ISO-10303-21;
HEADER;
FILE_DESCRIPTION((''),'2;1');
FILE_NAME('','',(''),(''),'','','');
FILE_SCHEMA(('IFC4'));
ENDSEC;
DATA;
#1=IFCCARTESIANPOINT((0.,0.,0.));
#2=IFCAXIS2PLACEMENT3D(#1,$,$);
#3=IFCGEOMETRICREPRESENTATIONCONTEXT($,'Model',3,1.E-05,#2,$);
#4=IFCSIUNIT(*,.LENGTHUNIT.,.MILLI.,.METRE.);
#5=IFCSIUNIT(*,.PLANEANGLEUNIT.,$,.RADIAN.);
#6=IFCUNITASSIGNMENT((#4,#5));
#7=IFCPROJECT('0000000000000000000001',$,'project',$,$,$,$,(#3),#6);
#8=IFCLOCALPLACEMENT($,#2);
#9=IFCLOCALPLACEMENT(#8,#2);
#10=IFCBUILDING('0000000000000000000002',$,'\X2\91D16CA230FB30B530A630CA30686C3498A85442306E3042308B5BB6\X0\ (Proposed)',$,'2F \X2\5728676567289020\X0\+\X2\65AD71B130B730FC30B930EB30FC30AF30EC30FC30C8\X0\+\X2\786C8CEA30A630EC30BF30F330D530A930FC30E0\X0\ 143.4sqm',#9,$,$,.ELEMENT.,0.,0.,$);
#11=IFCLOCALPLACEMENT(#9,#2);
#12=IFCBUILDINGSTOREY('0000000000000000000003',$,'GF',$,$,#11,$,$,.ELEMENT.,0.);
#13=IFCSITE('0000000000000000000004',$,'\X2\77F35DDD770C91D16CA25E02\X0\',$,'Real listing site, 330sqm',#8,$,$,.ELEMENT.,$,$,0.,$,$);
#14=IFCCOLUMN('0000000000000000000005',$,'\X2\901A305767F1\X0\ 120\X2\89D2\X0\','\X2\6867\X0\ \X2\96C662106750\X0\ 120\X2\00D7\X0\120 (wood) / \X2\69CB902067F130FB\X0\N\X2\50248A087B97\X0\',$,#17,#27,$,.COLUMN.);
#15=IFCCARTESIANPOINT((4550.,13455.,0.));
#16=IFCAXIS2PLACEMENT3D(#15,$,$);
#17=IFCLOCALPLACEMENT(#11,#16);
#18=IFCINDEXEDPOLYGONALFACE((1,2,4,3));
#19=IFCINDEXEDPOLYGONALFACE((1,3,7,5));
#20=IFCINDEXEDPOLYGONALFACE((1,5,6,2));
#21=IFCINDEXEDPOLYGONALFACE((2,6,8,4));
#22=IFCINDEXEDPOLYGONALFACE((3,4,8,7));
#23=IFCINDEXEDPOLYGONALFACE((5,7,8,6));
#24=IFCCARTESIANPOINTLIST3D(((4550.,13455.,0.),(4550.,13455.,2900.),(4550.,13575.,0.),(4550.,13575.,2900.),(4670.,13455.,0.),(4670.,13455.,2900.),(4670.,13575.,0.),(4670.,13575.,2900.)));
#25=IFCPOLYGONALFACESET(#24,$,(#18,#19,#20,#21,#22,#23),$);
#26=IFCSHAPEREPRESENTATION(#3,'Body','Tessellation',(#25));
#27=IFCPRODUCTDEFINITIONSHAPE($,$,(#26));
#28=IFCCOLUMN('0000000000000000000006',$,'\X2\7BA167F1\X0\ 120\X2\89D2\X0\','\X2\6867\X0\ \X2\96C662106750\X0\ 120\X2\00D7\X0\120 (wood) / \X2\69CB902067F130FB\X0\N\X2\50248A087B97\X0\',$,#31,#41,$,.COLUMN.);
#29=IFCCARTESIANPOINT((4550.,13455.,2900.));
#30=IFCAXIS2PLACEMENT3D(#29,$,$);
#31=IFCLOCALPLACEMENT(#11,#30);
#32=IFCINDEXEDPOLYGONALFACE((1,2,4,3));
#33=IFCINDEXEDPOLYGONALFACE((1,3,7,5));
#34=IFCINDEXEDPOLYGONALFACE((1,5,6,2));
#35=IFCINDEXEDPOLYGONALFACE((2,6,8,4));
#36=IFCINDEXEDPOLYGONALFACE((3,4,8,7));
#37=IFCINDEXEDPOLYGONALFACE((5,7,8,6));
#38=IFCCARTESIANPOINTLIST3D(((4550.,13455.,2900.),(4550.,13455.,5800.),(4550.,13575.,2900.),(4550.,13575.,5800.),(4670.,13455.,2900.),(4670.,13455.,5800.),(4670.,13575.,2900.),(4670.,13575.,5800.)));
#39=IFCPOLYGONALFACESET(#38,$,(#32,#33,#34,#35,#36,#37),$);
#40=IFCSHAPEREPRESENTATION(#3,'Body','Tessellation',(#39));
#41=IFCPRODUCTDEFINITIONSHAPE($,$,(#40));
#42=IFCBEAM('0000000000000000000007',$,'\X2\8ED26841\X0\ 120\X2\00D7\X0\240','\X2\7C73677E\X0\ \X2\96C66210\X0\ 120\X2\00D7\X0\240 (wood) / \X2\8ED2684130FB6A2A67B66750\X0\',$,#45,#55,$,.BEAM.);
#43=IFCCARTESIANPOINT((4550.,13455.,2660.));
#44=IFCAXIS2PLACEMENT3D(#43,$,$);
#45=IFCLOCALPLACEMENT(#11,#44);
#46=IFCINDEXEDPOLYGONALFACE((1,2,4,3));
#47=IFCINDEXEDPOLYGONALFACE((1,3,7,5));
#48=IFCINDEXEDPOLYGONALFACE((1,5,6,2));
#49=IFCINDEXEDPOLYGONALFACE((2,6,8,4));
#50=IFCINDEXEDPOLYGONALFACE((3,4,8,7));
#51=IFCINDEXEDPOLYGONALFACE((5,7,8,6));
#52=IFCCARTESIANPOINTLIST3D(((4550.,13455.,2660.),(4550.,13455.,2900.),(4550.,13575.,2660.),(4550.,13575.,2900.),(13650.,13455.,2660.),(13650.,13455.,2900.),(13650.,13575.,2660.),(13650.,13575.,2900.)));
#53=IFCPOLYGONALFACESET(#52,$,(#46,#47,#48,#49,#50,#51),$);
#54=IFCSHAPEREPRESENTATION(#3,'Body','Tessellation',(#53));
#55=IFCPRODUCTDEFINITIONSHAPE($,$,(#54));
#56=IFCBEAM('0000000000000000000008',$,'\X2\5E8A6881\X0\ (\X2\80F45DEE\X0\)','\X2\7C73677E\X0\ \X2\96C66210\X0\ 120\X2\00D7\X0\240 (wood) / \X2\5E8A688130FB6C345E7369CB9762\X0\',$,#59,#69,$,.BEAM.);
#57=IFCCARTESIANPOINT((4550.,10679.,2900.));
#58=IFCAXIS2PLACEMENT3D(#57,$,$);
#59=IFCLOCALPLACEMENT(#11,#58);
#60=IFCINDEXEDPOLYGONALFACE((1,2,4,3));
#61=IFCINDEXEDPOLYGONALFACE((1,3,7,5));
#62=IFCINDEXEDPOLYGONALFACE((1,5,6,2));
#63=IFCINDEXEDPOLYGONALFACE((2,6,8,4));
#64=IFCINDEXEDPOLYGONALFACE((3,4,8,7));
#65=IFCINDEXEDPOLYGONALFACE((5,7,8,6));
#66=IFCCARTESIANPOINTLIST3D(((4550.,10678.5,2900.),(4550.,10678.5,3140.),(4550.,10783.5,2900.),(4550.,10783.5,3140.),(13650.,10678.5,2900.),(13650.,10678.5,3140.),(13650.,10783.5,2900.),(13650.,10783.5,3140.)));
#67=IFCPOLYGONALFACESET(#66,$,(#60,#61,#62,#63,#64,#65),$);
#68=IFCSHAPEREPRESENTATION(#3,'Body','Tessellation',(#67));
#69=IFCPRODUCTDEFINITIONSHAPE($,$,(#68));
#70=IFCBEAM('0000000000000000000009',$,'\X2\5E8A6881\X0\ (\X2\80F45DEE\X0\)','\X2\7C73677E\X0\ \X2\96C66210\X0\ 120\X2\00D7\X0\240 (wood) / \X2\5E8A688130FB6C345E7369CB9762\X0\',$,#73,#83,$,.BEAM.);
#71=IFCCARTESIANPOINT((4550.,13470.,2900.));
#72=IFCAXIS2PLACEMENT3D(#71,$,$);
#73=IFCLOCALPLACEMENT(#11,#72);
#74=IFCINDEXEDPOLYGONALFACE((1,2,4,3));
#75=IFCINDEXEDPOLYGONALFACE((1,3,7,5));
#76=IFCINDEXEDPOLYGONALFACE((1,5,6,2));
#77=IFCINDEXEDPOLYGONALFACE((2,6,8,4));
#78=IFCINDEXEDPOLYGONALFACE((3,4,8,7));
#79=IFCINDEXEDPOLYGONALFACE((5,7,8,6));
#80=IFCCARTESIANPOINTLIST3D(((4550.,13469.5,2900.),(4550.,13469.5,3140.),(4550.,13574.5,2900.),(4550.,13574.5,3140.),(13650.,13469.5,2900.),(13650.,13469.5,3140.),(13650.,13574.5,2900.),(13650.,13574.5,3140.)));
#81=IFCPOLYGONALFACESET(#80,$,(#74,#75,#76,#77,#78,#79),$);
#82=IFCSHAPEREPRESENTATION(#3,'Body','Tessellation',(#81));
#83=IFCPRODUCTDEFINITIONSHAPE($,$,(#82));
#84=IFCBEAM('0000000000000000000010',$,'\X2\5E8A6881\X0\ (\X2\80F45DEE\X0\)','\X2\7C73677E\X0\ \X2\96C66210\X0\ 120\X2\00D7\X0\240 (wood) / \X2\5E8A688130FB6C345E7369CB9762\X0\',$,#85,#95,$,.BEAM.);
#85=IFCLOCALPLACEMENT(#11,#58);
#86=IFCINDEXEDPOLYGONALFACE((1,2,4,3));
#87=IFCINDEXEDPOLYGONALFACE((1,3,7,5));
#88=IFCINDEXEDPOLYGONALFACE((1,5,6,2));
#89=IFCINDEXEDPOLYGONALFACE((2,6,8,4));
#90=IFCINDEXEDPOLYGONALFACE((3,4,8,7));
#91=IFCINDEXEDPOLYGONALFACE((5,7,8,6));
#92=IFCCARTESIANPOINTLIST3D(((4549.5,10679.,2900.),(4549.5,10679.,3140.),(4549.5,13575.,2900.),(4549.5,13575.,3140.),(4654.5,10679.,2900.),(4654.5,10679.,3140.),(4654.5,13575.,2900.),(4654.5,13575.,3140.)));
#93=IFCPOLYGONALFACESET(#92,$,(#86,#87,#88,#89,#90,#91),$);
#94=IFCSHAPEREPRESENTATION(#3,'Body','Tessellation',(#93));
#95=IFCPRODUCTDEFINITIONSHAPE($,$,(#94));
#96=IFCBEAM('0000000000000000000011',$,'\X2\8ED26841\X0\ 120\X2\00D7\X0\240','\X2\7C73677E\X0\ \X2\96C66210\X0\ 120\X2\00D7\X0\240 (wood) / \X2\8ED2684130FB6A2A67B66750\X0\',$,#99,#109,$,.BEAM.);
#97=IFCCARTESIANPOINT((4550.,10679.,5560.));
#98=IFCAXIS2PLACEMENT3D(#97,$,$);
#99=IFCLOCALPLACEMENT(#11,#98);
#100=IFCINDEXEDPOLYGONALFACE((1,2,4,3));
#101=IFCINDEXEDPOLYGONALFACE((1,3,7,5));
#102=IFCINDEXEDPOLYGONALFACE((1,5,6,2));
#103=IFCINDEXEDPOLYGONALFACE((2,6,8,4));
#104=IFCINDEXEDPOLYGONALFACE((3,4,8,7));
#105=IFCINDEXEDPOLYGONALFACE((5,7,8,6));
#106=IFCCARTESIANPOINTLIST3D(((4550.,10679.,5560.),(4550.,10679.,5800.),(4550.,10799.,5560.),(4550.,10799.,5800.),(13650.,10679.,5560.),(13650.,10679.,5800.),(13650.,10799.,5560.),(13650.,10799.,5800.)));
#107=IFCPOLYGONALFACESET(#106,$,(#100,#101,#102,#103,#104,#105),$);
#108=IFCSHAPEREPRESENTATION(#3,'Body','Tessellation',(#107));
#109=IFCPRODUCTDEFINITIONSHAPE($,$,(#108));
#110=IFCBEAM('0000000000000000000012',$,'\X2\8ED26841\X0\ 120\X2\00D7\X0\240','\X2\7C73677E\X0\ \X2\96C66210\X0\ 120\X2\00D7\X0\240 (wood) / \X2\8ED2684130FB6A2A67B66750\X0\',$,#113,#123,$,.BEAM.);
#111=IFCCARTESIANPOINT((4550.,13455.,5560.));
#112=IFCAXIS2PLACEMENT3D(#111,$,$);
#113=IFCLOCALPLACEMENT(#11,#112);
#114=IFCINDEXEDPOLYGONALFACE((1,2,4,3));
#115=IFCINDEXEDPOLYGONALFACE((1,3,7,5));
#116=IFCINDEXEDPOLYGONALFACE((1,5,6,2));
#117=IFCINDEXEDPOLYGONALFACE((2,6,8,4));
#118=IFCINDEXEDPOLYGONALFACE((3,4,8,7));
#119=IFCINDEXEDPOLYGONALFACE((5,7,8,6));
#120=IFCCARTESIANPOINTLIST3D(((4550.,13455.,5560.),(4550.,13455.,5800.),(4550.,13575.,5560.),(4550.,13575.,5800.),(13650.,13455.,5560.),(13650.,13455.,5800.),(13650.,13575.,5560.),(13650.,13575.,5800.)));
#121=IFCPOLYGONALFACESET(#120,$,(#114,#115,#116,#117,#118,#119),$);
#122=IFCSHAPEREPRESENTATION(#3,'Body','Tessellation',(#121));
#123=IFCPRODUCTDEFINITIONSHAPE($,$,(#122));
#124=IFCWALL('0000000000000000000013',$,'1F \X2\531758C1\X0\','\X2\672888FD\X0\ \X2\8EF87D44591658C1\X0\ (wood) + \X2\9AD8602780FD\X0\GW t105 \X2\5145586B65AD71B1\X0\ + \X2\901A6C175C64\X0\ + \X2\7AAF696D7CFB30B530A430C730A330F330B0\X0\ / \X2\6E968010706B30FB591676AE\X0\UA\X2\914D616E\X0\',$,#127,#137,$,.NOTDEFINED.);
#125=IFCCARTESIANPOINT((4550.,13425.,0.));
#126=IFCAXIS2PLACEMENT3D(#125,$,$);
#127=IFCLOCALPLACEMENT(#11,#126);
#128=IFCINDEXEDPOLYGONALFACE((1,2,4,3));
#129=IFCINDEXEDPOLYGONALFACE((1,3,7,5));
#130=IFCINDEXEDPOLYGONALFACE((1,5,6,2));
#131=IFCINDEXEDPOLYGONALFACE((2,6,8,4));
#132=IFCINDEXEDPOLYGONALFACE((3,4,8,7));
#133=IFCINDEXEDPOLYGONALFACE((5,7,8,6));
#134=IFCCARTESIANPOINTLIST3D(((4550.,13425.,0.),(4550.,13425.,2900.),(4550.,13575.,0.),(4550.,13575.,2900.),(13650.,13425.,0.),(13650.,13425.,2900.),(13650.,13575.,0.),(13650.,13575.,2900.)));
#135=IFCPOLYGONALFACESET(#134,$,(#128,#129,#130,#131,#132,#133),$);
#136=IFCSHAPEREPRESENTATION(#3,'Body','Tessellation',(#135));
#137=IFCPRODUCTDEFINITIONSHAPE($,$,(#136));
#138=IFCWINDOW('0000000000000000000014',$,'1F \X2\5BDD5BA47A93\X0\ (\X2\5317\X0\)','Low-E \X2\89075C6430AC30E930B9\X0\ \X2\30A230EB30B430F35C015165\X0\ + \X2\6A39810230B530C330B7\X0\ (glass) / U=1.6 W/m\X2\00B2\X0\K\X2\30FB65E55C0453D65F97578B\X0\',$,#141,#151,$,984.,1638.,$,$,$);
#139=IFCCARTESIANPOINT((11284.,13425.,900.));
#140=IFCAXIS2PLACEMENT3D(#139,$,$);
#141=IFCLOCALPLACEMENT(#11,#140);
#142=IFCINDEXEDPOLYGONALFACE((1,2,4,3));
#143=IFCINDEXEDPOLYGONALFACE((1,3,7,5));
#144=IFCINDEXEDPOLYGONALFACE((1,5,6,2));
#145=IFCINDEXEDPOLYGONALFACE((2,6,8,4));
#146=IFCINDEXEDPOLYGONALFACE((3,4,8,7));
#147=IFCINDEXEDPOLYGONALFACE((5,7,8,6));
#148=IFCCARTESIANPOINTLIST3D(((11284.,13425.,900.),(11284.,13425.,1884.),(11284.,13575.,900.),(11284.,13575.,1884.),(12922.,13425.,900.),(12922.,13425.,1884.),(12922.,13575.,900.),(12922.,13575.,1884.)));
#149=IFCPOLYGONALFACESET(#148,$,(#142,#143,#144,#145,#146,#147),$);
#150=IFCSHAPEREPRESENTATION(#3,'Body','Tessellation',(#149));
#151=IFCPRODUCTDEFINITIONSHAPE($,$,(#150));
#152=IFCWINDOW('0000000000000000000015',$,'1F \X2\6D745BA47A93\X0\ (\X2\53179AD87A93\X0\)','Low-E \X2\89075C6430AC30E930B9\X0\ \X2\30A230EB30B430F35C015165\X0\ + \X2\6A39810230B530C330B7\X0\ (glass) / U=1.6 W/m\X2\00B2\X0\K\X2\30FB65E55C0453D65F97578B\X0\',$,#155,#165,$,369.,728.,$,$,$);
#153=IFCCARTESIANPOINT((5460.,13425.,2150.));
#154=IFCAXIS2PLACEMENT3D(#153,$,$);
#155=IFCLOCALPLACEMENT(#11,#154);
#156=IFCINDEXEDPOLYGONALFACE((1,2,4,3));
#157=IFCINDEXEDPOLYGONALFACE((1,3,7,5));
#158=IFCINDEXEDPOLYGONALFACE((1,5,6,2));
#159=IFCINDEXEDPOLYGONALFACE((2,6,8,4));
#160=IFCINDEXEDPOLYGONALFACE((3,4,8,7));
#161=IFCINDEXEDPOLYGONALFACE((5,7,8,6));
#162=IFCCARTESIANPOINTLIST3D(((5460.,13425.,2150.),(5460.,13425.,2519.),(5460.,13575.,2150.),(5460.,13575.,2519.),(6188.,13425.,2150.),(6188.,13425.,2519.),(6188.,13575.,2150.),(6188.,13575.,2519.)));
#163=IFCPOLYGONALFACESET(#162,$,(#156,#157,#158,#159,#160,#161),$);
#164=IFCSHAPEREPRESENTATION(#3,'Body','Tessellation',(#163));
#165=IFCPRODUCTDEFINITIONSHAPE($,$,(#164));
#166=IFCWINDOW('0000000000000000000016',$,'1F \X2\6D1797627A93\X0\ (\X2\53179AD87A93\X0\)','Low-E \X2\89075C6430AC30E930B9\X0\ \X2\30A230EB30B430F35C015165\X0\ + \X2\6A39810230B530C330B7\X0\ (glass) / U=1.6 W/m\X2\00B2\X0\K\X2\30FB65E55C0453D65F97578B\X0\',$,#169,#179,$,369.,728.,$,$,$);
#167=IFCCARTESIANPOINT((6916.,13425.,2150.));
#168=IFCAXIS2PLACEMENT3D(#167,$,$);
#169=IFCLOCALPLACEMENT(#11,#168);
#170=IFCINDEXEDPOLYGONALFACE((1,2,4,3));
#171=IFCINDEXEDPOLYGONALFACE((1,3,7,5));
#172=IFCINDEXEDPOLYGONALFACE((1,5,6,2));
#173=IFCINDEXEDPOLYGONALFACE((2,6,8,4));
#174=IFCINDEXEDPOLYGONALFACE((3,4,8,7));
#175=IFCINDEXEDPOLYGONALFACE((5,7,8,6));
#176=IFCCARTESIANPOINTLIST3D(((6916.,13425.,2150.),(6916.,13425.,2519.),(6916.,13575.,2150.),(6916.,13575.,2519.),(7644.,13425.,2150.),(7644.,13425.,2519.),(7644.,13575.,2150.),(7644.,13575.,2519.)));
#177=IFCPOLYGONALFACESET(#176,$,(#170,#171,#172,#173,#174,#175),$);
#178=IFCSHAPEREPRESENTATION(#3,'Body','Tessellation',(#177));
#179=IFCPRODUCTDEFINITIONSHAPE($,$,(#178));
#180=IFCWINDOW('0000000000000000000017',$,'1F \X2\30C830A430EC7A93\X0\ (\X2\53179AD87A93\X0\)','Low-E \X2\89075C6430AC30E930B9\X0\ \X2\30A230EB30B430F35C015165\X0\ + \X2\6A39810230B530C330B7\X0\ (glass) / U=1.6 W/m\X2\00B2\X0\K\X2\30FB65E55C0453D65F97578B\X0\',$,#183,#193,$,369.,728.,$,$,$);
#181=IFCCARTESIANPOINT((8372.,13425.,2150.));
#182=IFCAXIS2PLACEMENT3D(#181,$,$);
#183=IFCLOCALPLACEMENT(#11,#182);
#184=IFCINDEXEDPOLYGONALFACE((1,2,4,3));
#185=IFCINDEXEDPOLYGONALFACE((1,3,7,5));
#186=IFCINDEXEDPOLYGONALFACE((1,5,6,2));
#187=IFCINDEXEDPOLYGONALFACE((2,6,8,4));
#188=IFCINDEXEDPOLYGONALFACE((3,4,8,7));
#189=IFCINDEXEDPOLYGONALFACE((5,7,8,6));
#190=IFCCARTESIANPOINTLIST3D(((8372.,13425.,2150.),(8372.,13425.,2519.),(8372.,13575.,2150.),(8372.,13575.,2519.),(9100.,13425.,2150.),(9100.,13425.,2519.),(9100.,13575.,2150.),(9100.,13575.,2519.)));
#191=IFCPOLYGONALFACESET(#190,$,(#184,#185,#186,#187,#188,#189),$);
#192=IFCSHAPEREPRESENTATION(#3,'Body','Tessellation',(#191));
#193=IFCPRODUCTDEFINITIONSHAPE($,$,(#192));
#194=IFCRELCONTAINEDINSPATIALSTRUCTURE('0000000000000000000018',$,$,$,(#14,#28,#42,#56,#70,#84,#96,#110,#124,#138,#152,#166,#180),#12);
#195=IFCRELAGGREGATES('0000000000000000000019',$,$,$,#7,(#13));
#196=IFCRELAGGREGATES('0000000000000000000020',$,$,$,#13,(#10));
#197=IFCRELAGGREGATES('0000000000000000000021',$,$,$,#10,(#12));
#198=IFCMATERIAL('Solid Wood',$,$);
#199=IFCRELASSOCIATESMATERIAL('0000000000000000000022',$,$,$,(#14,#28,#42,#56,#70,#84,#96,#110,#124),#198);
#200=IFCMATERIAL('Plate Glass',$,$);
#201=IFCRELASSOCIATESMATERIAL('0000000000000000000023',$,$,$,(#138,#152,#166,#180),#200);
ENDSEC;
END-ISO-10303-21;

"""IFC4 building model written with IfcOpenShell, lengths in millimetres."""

from ifc_helpers import new_model, si_unit, frame, frame_2d, origin, place, context, project, spatial, rectangle, extrude, material, element, fill, save


model = new_model("IFC4")

# Units and contexts
model_context = context("Model", 3, precision=1e-05, world=origin())
ifc_project = project(units=[si_unit("LENGTHUNIT", "METRE", prefix="MILLI"), si_unit("PLANEANGLEUNIT", "RADIAN")], contexts=[model_context])

# Site, building, storey
site_placement = place(None, origin())
site = spatial("IfcSite", under=ifc_project, at=site_placement, Name="石川県金沢市", ObjectType="Real listing site, 330sqm", CompositionType="ELEMENT", RefElevation=0.0)
building_placement = place(site_placement, origin())
building = spatial("IfcBuilding", under=site, at=building_placement, Name="金沢・サウナと水風呂のある家 (Proposed)", ObjectType="2F 在来木造+断熱シースルークレート+硬質ウレタンフォーム 143.4sqm", CompositionType="ELEMENT", ElevationOfRefHeight=0.0, ElevationOfTerrain=0.0)
storey_placement = place(building_placement, origin())
storey = spatial("IfcBuildingStorey", under=building, at=storey_placement, Name="GF", CompositionType="ELEMENT", Elevation=0.0)

# Columns
ifc_material_1 = material(Name="Solid Wood")
column_1_placement = place(storey_placement, frame((4550.0, 13455.0, 0.0)))
element("IfcColumn", 1, at=column_1_placement, inside=storey, material=ifc_material_1, Name="通し柱 120角", Description="桧 集成材 120×120 (wood) / 構造柱・N値計算", PredefinedType="COLUMN", context=model_context, shape_type="SweptSolid", body=[
    extrude(rectangle(XDim=120.0, YDim=120.0, at=frame_2d((60.0, 60.0))), frame((4550.0, 13455.0, 0.0)), (0.0, 0.0, 1.0), 2900.0),
])
column_2_placement = place(storey_placement, frame((4550.0, 13455.0, 2900.0)))
element("IfcColumn", 2, at=column_2_placement, inside=storey, material=ifc_material_1, Name="管柱 120角", Description="桧 集成材 120×120 (wood) / 構造柱・N値計算", PredefinedType="COLUMN", context=model_context, shape_type="SweptSolid", body=[
    extrude(rectangle(XDim=120.0, YDim=120.0, at=frame_2d((60.0, 60.0))), frame((4550.0, 13455.0, 2900.0)), (0.0, 0.0, 1.0), 2900.0),
])

# Beams
beam_1_placement = place(storey_placement, frame((4550.0, 13455.0, 2660.0)))
element("IfcBeam", 3, at=beam_1_placement, inside=storey, material=ifc_material_1, Name="軒桁 120×240", Description="米松 集成 120×240 (wood) / 軒桁・横架材", PredefinedType="BEAM", context=model_context, shape_type="SweptSolid", body=[
    extrude(rectangle(XDim=9100.0, YDim=120.0, at=frame_2d((4550.0, 60.0))), frame((4550.0, 13455.0, 2660.0)), (0.0, 0.0, 1.0), 240.0),
])
beam_2_placement = place(storey_placement, frame((4550.0, 10679.0, 2900.0)))
element("IfcBeam", 4, at=beam_2_placement, inside=storey, material=ifc_material_1, Name="床梁 (胴差)", Description="米松 集成 120×240 (wood) / 床梁・水平構面", PredefinedType="BEAM", context=model_context, shape_type="SweptSolid", body=[
    extrude(rectangle(XDim=9100.0, YDim=105.0, at=frame_2d((4550.0, 52.0))), frame((4550.0, 10679.0, 2900.0)), (0.0, 0.0, 1.0), 240.0),
])
beam_3_placement = place(storey_placement, frame((4550.0, 13470.0, 2900.0)))
element("IfcBeam", 5, at=beam_3_placement, inside=storey, material=ifc_material_1, Name="床梁 (胴差)", Description="米松 集成 120×240 (wood) / 床梁・水平構面", PredefinedType="BEAM", context=model_context, shape_type="SweptSolid", body=[
    extrude(rectangle(XDim=9100.0, YDim=105.0, at=frame_2d((4550.0, 52.0))), frame((4550.0, 13470.0, 2900.0)), (0.0, 0.0, 1.0), 240.0),
])
beam_4_placement = place(storey_placement, frame((4550.0, 10679.0, 2900.0)))
element("IfcBeam", 6, at=beam_4_placement, inside=storey, material=ifc_material_1, Name="床梁 (胴差)", Description="米松 集成 120×240 (wood) / 床梁・水平構面", PredefinedType="BEAM", context=model_context, shape_type="SweptSolid", body=[
    extrude(rectangle(XDim=105.0, YDim=2896.0, at=frame_2d((52.0, 1448.0))), frame((4550.0, 10679.0, 2900.0)), (0.0, 0.0, 1.0), 240.0),
])
beam_5_placement = place(storey_placement, frame((4550.0, 10679.0, 5560.0)))
element("IfcBeam", 7, at=beam_5_placement, inside=storey, material=ifc_material_1, Name="軒桁 120×240", Description="米松 集成 120×240 (wood) / 軒桁・横架材", PredefinedType="BEAM", context=model_context, shape_type="SweptSolid", body=[
    extrude(rectangle(XDim=9100.0, YDim=120.0, at=frame_2d((4550.0, 60.0))), frame((4550.0, 10679.0, 5560.0)), (0.0, 0.0, 1.0), 240.0),
])
beam_6_placement = place(storey_placement, frame((4550.0, 13455.0, 5560.0)))
element("IfcBeam", 8, at=beam_6_placement, inside=storey, material=ifc_material_1, Name="軒桁 120×240", Description="米松 集成 120×240 (wood) / 軒桁・横架材", PredefinedType="BEAM", context=model_context, shape_type="SweptSolid", body=[
    extrude(rectangle(XDim=9100.0, YDim=120.0, at=frame_2d((4550.0, 60.0))), frame((4550.0, 13455.0, 5560.0)), (0.0, 0.0, 1.0), 240.0),
])

# Wall, openings, windows
wall_1_placement = place(storey_placement, frame((4550.0, 13425.0, 0.0)))
wall_1 = element("IfcWall", 9, at=wall_1_placement, inside=storey, material=ifc_material_1, Name="1F 北壁", Description="木製 軸組外壁 (wood) + 高性能GW t105 充填断熱 + 通気層 + 窯業系サイディング / 準耐火・外皮UA配慮", PredefinedType="NOTDEFINED", context=model_context, shape_type="SweptSolid", body=[
    extrude(rectangle(XDim=9100.0, YDim=150.0, at=frame_2d((4550.0, 75.0))), frame((4550.0, 13425.0, 0.0)), (0.0, 0.0, 1.0), 2900.0),
])
opening_1_placement = place(storey_placement, frame((11284.0, 13425.0, 900.0)))
opening_1 = element("IfcOpeningElement", 10, at=opening_1_placement, cuts=wall_1, PredefinedType="NOTDEFINED", context=model_context, shape_type="SweptSolid", body=[
    extrude(rectangle(XDim=1638.0, YDim=150.0, at=frame_2d((819.0, 75.0))), frame((11284.0, 13425.0, 900.0)), (0.0, 0.0, 1.0), 984.0),
])
opening_2_placement = place(storey_placement, frame((5460.0, 13425.0, 2150.0)))
opening_2 = element("IfcOpeningElement", 11, at=opening_2_placement, cuts=wall_1, PredefinedType="NOTDEFINED", context=model_context, shape_type="SweptSolid", body=[
    extrude(rectangle(XDim=728.0, YDim=150.0, at=frame_2d((364.0, 75.0))), frame((5460.0, 13425.0, 2150.0)), (0.0, 0.0, 1.0), 369.0),
])
opening_3_placement = place(storey_placement, frame((6916.0, 13425.0, 2150.0)))
opening_3 = element("IfcOpeningElement", 12, at=opening_3_placement, cuts=wall_1, PredefinedType="NOTDEFINED", context=model_context, shape_type="SweptSolid", body=[
    extrude(rectangle(XDim=728.0, YDim=150.0, at=frame_2d((364.0, 75.0))), frame((6916.0, 13425.0, 2150.0)), (0.0, 0.0, 1.0), 369.0),
])
opening_4_placement = place(storey_placement, frame((8372.0, 13425.0, 2150.0)))
opening_4 = element("IfcOpeningElement", 13, at=opening_4_placement, cuts=wall_1, PredefinedType="NOTDEFINED", context=model_context, shape_type="SweptSolid", body=[
    extrude(rectangle(XDim=728.0, YDim=150.0, at=frame_2d((364.0, 75.0))), frame((8372.0, 13425.0, 2150.0)), (0.0, 0.0, 1.0), 369.0),
])
ifc_material_2 = material(Name="Plate Glass")
window_1_placement = place(storey_placement, frame((11284.0, 13425.0, 900.0)))
window_1 = element("IfcWindow", 14, at=window_1_placement, inside=storey, material=ifc_material_2, Name="1F 寝室窓 (北)", Description="Low-E 複層ガラス アルゴン封入 + 樹脂サッシ (glass) / U=1.6 W/m²K・日射取得型", OverallHeight=984.0, OverallWidth=1638.0, context=model_context, shape_type="SweptSolid", body=[
    extrude(rectangle(XDim=1638.0, YDim=150.0, at=frame_2d((819.0, 75.0))), frame((11284.0, 13425.0, 900.0)), (0.0, 0.0, 1.0), 984.0),
])
fill(opening_1, window_1)
window_2_placement = place(storey_placement, frame((5460.0, 13425.0, 2150.0)))
window_2 = element("IfcWindow", 15, at=window_2_placement, inside=storey, material=ifc_material_2, Name="1F 浴室窓 (北高窓)", Description="Low-E 複層ガラス アルゴン封入 + 樹脂サッシ (glass) / U=1.6 W/m²K・日射取得型", OverallHeight=369.0, OverallWidth=728.0, context=model_context, shape_type="SweptSolid", body=[
    extrude(rectangle(XDim=728.0, YDim=150.0, at=frame_2d((364.0, 75.0))), frame((5460.0, 13425.0, 2150.0)), (0.0, 0.0, 1.0), 369.0),
])
fill(opening_2, window_2)
window_3_placement = place(storey_placement, frame((6916.0, 13425.0, 2150.0)))
window_3 = element("IfcWindow", 16, at=window_3_placement, inside=storey, material=ifc_material_2, Name="1F 洗面窓 (北高窓)", Description="Low-E 複層ガラス アルゴン封入 + 樹脂サッシ (glass) / U=1.6 W/m²K・日射取得型", OverallHeight=369.0, OverallWidth=728.0, context=model_context, shape_type="SweptSolid", body=[
    extrude(rectangle(XDim=728.0, YDim=150.0, at=frame_2d((364.0, 75.0))), frame((6916.0, 13425.0, 2150.0)), (0.0, 0.0, 1.0), 369.0),
])
fill(opening_3, window_3)
window_4_placement = place(storey_placement, frame((8372.0, 13425.0, 2150.0)))
window_4 = element("IfcWindow", 17, at=window_4_placement, inside=storey, material=ifc_material_2, Name="1F トイレ窓 (北高窓)", Description="Low-E 複層ガラス アルゴン封入 + 樹脂サッシ (glass) / U=1.6 W/m²K・日射取得型", OverallHeight=369.0, OverallWidth=728.0, context=model_context, shape_type="SweptSolid", body=[
    extrude(rectangle(XDim=728.0, YDim=150.0, at=frame_2d((364.0, 75.0))), frame((8372.0, 13425.0, 2150.0)), (0.0, 0.0, 1.0), 369.0),
])
fill(opening_4, window_4)

save(model, "model.ifc")
